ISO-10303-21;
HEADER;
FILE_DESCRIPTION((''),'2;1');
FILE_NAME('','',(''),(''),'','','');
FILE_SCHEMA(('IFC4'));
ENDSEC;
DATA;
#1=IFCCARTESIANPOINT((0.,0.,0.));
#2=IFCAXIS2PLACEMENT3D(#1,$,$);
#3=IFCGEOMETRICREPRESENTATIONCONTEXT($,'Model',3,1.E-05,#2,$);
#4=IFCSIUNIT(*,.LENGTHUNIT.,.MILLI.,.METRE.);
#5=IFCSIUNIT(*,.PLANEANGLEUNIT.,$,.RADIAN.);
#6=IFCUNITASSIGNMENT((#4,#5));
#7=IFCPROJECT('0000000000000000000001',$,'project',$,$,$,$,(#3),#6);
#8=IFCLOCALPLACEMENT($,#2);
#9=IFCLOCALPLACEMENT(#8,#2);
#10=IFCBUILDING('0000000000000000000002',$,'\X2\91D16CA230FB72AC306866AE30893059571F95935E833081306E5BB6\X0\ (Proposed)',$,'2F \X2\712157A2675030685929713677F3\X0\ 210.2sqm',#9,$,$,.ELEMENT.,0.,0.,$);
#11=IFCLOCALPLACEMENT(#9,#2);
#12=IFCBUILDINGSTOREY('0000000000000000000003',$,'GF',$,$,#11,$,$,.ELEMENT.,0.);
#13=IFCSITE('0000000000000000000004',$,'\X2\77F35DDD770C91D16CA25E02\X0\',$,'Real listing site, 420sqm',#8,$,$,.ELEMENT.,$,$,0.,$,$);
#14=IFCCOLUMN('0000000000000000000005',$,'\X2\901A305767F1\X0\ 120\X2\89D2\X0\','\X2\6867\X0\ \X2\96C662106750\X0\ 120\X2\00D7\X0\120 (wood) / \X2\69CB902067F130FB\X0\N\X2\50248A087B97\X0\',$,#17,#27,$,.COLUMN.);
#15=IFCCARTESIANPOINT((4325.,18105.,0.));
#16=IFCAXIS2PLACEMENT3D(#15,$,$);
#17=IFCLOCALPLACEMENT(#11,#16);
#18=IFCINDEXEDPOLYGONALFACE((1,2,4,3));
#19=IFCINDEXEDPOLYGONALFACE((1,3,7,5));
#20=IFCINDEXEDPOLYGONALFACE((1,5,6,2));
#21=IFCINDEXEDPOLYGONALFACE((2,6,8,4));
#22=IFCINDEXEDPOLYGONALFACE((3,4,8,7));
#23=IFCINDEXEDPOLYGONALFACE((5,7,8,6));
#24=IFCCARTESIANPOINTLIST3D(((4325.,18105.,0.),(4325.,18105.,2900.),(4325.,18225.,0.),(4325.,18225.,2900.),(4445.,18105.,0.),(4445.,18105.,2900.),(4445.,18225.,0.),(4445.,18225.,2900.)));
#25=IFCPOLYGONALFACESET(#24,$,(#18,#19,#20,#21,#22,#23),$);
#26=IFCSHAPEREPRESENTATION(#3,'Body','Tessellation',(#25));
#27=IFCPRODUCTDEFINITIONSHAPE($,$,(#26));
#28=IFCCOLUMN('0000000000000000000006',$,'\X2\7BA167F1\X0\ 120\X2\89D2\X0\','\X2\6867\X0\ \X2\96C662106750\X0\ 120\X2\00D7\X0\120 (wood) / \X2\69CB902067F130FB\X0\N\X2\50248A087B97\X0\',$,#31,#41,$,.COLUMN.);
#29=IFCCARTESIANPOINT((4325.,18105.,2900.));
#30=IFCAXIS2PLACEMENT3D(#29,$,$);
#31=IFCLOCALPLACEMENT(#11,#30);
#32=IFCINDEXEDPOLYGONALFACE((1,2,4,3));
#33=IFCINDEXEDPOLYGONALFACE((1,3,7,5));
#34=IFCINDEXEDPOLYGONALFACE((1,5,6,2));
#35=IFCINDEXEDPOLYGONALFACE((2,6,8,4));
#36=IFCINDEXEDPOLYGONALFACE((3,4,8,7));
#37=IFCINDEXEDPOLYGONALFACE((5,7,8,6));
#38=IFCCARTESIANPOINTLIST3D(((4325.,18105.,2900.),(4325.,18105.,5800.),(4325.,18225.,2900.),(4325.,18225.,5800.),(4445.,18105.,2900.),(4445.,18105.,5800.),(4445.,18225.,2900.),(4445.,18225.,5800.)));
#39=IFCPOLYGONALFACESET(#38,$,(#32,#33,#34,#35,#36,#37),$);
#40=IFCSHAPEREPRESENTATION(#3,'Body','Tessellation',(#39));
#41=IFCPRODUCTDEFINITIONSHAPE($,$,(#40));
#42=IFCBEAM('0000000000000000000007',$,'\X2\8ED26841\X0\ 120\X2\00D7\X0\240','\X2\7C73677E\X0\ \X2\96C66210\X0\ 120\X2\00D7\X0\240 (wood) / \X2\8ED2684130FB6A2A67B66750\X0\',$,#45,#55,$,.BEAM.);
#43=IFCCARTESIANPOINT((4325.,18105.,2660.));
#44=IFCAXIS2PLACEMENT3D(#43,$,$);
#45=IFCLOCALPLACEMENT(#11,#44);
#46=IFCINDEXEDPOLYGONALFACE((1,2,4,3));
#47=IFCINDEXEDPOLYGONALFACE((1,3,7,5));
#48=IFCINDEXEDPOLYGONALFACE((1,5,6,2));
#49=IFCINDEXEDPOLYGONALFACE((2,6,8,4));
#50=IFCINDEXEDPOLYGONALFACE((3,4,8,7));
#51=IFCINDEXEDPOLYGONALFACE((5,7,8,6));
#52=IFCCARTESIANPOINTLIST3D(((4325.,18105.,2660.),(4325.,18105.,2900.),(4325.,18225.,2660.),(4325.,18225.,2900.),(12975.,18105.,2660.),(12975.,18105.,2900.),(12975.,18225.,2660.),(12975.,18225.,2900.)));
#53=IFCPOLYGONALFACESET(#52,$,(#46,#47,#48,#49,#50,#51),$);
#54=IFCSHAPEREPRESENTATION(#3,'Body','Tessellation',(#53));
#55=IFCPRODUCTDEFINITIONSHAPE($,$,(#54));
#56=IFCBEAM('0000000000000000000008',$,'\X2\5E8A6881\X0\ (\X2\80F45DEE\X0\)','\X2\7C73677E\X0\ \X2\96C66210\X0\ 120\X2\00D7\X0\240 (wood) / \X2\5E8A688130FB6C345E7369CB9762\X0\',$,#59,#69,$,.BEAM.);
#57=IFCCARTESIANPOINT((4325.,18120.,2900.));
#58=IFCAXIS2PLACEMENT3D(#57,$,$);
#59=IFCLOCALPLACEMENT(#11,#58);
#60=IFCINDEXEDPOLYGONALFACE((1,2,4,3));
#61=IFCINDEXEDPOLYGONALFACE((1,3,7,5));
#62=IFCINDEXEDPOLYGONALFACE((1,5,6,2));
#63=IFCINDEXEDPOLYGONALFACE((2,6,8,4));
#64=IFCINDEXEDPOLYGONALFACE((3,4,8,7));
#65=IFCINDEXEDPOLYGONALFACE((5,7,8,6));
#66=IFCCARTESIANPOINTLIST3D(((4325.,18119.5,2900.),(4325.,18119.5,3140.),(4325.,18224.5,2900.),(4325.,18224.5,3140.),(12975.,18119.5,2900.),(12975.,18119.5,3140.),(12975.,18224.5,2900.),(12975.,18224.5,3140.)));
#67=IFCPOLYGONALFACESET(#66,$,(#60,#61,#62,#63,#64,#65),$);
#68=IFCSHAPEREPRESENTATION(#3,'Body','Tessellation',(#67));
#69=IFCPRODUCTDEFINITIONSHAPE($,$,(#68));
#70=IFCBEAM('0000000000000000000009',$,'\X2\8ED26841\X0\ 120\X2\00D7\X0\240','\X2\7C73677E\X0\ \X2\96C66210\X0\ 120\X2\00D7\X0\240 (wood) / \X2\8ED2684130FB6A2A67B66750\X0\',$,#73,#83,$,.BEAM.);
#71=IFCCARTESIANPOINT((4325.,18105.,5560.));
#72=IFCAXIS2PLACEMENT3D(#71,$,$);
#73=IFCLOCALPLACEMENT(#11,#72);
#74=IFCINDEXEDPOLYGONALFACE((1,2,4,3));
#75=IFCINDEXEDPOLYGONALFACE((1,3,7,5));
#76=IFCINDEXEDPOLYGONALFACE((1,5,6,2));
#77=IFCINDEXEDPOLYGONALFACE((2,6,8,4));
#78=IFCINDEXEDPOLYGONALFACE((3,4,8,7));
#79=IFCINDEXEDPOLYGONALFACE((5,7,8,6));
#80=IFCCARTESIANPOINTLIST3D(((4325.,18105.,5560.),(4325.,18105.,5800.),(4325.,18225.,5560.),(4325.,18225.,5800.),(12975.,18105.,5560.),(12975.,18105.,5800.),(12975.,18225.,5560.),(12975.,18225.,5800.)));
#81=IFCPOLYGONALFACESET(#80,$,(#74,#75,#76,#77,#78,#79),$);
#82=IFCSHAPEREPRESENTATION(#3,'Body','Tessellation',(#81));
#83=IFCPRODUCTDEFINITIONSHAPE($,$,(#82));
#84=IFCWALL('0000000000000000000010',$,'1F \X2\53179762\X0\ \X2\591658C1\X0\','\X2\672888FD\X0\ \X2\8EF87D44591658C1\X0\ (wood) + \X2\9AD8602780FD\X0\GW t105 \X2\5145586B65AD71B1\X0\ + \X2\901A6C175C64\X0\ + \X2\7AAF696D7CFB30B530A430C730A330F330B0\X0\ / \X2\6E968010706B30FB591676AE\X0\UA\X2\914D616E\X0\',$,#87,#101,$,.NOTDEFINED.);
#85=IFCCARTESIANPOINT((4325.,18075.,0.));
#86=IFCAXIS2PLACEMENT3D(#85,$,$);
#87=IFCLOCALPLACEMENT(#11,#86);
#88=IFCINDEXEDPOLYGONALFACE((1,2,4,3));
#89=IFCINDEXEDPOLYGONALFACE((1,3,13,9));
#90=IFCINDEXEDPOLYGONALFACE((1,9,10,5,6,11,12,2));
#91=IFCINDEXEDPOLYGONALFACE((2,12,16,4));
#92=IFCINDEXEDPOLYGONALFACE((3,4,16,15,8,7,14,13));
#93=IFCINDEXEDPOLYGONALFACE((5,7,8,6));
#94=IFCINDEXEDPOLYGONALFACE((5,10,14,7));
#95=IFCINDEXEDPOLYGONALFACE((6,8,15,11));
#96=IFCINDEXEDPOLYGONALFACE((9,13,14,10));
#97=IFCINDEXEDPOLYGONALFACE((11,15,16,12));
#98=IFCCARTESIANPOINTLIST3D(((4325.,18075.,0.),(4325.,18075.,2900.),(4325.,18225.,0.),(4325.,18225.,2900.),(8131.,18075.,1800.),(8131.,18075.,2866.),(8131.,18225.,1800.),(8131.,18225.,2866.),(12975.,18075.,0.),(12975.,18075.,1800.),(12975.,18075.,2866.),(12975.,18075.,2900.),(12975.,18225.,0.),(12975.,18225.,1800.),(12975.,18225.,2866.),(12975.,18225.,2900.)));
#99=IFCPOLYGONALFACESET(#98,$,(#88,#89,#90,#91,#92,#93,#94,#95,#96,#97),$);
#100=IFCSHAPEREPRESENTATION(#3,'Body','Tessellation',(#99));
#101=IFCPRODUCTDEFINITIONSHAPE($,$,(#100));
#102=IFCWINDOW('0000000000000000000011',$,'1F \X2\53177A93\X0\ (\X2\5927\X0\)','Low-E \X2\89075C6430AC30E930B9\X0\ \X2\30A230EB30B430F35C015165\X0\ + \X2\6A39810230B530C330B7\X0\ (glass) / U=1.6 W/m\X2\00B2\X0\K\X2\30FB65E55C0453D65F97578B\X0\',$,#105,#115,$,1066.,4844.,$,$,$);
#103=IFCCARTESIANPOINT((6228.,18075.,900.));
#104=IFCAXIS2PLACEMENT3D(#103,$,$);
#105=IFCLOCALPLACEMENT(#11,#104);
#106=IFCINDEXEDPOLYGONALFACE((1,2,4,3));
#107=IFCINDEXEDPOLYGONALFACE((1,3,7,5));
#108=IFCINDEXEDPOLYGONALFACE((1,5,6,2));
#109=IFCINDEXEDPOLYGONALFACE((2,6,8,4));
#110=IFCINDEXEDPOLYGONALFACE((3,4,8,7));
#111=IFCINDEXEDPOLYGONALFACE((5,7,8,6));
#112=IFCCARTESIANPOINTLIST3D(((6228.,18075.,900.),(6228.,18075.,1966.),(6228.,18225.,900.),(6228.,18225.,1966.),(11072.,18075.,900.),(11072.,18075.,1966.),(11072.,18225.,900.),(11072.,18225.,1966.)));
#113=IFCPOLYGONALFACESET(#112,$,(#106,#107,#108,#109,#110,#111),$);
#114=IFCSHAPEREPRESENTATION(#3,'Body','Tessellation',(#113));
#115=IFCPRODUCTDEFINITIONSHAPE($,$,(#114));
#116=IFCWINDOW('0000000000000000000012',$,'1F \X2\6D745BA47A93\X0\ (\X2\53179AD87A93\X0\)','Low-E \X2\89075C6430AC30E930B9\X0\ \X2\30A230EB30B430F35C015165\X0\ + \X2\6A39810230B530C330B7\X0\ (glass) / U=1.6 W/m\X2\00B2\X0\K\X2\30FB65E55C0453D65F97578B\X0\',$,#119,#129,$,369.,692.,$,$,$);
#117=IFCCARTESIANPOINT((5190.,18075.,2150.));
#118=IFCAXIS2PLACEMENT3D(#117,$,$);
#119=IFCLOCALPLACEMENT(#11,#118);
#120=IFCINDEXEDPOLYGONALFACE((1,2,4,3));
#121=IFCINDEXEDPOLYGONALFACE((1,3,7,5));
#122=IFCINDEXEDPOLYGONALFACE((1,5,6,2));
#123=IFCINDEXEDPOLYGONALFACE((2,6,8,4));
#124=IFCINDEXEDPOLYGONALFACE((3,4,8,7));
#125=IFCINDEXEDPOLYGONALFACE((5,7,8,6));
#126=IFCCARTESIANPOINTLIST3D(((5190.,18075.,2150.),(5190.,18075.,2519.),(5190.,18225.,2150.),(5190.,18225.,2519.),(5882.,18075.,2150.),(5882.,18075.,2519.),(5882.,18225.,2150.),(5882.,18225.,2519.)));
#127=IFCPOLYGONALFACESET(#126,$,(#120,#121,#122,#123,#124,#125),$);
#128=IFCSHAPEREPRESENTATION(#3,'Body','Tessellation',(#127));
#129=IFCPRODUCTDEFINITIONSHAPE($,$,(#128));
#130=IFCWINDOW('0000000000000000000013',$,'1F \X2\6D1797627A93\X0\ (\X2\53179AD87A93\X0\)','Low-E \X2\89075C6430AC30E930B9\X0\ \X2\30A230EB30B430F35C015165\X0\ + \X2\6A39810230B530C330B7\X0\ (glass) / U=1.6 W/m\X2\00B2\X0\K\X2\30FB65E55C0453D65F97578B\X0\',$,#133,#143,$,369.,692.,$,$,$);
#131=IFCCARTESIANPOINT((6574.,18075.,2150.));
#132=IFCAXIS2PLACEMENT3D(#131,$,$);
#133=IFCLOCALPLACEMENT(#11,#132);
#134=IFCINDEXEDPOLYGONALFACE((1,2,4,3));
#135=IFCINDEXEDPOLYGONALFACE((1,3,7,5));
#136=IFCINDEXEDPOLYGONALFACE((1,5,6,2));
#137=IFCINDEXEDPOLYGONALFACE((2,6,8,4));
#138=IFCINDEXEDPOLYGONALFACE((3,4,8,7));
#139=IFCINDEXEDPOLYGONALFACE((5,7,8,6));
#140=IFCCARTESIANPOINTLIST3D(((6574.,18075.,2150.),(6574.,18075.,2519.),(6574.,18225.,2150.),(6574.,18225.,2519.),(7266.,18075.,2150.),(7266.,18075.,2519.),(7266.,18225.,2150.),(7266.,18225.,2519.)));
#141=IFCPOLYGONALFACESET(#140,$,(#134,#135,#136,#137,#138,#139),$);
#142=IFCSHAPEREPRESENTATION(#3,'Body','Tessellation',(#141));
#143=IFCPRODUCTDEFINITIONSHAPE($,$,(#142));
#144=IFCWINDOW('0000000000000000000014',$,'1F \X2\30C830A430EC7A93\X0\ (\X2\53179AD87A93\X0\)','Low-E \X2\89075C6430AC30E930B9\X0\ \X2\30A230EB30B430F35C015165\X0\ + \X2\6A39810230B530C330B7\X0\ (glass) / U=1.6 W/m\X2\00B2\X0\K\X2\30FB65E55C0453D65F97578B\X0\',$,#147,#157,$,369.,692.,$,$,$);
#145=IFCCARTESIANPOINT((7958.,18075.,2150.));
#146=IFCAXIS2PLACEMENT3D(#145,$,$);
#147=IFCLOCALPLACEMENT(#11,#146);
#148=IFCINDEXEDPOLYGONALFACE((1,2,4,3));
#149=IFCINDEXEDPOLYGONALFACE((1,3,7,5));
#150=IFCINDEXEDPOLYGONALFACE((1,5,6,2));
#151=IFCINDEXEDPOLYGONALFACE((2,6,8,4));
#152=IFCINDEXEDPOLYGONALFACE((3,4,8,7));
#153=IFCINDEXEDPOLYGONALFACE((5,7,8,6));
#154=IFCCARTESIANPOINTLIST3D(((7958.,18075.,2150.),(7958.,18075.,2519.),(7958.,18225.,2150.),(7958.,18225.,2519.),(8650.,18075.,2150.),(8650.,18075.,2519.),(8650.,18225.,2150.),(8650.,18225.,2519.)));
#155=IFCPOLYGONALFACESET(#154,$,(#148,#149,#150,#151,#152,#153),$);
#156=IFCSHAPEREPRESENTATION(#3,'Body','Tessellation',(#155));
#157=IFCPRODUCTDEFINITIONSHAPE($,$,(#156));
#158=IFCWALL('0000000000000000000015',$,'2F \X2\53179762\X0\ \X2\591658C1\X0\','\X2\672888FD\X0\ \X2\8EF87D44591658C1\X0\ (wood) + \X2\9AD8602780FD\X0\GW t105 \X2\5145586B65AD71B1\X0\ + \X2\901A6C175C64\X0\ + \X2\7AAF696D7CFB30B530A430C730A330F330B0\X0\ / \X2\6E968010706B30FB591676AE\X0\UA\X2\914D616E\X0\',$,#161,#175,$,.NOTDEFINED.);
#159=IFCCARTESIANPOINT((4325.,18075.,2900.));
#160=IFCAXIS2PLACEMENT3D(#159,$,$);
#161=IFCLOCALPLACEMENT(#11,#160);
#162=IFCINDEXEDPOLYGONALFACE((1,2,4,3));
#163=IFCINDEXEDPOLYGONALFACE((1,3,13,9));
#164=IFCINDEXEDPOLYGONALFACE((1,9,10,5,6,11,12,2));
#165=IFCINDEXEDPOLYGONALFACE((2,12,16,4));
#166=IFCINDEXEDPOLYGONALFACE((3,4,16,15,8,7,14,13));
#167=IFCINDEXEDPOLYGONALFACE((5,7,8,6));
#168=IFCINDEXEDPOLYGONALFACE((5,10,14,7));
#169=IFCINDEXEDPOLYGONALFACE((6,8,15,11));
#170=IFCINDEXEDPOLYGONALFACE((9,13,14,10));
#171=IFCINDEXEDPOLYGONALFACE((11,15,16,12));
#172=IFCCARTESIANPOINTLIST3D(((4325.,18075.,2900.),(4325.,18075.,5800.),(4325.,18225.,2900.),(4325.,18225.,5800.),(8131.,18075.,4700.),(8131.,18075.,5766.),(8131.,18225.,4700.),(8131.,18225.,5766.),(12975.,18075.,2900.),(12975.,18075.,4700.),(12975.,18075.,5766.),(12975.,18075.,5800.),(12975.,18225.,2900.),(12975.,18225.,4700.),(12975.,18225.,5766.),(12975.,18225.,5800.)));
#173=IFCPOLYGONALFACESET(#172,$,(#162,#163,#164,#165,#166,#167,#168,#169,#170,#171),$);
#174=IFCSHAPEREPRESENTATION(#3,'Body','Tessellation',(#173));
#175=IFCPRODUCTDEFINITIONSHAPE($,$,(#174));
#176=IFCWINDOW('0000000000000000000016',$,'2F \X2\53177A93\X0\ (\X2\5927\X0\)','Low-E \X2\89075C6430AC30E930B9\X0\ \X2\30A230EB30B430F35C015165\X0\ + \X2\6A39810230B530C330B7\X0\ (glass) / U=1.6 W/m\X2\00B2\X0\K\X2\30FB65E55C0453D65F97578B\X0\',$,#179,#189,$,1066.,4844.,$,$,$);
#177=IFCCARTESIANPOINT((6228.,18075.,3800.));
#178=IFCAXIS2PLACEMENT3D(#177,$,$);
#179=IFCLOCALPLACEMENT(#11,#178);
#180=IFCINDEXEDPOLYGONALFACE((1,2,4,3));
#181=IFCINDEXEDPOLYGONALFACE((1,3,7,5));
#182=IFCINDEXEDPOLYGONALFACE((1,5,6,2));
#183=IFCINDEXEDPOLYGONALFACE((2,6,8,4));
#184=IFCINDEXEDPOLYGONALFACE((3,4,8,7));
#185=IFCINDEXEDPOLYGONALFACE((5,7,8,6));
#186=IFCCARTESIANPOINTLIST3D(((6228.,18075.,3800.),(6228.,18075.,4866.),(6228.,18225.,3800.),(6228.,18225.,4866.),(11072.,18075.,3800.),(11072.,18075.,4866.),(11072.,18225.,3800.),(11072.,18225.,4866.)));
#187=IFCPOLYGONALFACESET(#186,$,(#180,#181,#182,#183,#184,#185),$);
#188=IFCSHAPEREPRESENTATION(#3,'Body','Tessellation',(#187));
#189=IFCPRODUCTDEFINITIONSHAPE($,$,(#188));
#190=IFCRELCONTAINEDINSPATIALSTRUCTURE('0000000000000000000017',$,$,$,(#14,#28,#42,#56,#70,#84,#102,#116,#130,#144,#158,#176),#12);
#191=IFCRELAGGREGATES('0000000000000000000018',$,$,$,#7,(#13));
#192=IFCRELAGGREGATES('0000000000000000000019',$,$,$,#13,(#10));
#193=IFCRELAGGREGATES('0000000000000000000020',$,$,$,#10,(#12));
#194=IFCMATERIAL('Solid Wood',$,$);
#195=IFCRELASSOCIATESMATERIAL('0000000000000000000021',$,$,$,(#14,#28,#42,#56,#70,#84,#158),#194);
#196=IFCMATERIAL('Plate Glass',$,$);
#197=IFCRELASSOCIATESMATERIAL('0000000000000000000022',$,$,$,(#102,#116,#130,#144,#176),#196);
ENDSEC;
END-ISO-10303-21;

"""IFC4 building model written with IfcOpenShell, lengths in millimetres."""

from ifc_helpers import new_model, si_unit, frame, frame_2d, origin, place, context, project, spatial, rectangle, extrude, material, element, fill, save


model = new_model("IFC4")

# Units and contexts
model_context = context("Model", 3, precision=1e-05, world=origin())
ifc_project = project(units=[si_unit("LENGTHUNIT", "METRE", prefix="MILLI"), si_unit("PLANEANGLEUNIT", "RADIAN")], contexts=[model_context])

# Site, building, storey
site_placement = place(None, origin())
site = spatial("IfcSite", under=ifc_project, at=site_placement, Name="石川県金沢市", ObjectType="Real listing site, 420sqm", CompositionType="ELEMENT", RefElevation=0.0)
building_placement = place(site_placement, origin())
building = spatial("IfcBuilding", under=site, at=building_placement, Name="金沢・犬と暮らす土間広めの家 (Proposed)", ObjectType="2F 無垢材と天然石 210.2sqm", CompositionType="ELEMENT", ElevationOfRefHeight=0.0, ElevationOfTerrain=0.0)
storey_placement = place(building_placement, origin())
storey = spatial("IfcBuildingStorey", under=building, at=storey_placement, Name="GF", CompositionType="ELEMENT", Elevation=0.0)

# Columns
ifc_material_1 = material(Name="Solid Wood")
column_1_placement = place(storey_placement, frame((4325.0, 18105.0, 0.0)))
element("IfcColumn", 1, at=column_1_placement, inside=storey, material=ifc_material_1, Name="通し柱 120角", Description="桧 集成材 120×120 (wood) / 構造柱・N値計算", PredefinedType="COLUMN", context=model_context, shape_type="SweptSolid", body=[
    extrude(rectangle(XDim=120.0, YDim=120.0, at=frame_2d((60.0, 60.0))), frame((4325.0, 18105.0, 0.0)), (0.0, 0.0, 1.0), 2900.0),
])
column_2_placement = place(storey_placement, frame((4325.0, 18105.0, 2900.0)))
element("IfcColumn", 2, at=column_2_placement, inside=storey, material=ifc_material_1, Name="管柱 120角", Description="桧 集成材 120×120 (wood) / 構造柱・N値計算", PredefinedType="COLUMN", context=model_context, shape_type="SweptSolid", body=[
    extrude(rectangle(XDim=120.0, YDim=120.0, at=frame_2d((60.0, 60.0))), frame((4325.0, 18105.0, 2900.0)), (0.0, 0.0, 1.0), 2900.0),
])

# Beams
beam_1_placement = place(storey_placement, frame((4325.0, 18105.0, 2660.0)))
element("IfcBeam", 3, at=beam_1_placement, inside=storey, material=ifc_material_1, Name="軒桁 120×240", Description="米松 集成 120×240 (wood) / 軒桁・横架材", PredefinedType="BEAM", context=model_context, shape_type="SweptSolid", body=[
    extrude(rectangle(XDim=8650.0, YDim=120.0, at=frame_2d((4325.0, 60.0))), frame((4325.0, 18105.0, 2660.0)), (0.0, 0.0, 1.0), 240.0),
])
beam_2_placement = place(storey_placement, frame((4325.0, 18120.0, 2900.0)))
element("IfcBeam", 4, at=beam_2_placement, inside=storey, material=ifc_material_1, Name="床梁 (胴差)", Description="米松 集成 120×240 (wood) / 床梁・水平構面", PredefinedType="BEAM", context=model_context, shape_type="SweptSolid", body=[
    extrude(rectangle(XDim=8650.0, YDim=105.0, at=frame_2d((4325.0, 52.0))), frame((4325.0, 18120.0, 2900.0)), (0.0, 0.0, 1.0), 240.0),
])
beam_3_placement = place(storey_placement, frame((4325.0, 18105.0, 5560.0)))
element("IfcBeam", 5, at=beam_3_placement, inside=storey, material=ifc_material_1, Name="軒桁 120×240", Description="米松 集成 120×240 (wood) / 軒桁・横架材", PredefinedType="BEAM", context=model_context, shape_type="SweptSolid", body=[
    extrude(rectangle(XDim=8650.0, YDim=120.0, at=frame_2d((4325.0, 60.0))), frame((4325.0, 18105.0, 5560.0)), (0.0, 0.0, 1.0), 240.0),
])

# Wall, openings, windows
wall_1_placement = place(storey_placement, frame((4325.0, 18075.0, 0.0)))
wall_1 = element("IfcWall", 6, at=wall_1_placement, inside=storey, material=ifc_material_1, Name="1F 北面 外壁", Description="木製 軸組外壁 (wood) + 高性能GW t105 充填断熱 + 通気層 + 窯業系サイディング / 準耐火・外皮UA配慮", PredefinedType="NOTDEFINED", context=model_context, shape_type="SweptSolid", body=[
    extrude(rectangle(XDim=8650.0, YDim=150.0, at=frame_2d((4325.0, 75.0))), frame((4325.0, 18075.0, 0.0)), (0.0, 0.0, 1.0), 2900.0),
])
opening_1_placement = place(storey_placement, frame((6228.0, 18075.0, 900.0)))
opening_1 = element("IfcOpeningElement", 7, at=opening_1_placement, cuts=wall_1, PredefinedType="NOTDEFINED", context=model_context, shape_type="SweptSolid", body=[
    extrude(rectangle(XDim=4844.0, YDim=150.0, at=frame_2d((2422.0, 75.0))), frame((6228.0, 18075.0, 900.0)), (0.0, 0.0, 1.0), 1066.0),
])
opening_2_placement = place(storey_placement, frame((5190.0, 18075.0, 2150.0)))
opening_2 = element("IfcOpeningElement", 8, at=opening_2_placement, cuts=wall_1, PredefinedType="NOTDEFINED", context=model_context, shape_type="SweptSolid", body=[
    extrude(rectangle(XDim=692.0, YDim=150.0, at=frame_2d((346.0, 75.0))), frame((5190.0, 18075.0, 2150.0)), (0.0, 0.0, 1.0), 369.0),
])
opening_3_placement = place(storey_placement, frame((6574.0, 18075.0, 2150.0)))
opening_3 = element("IfcOpeningElement", 9, at=opening_3_placement, cuts=wall_1, PredefinedType="NOTDEFINED", context=model_context, shape_type="SweptSolid", body=[
    extrude(rectangle(XDim=692.0, YDim=150.0, at=frame_2d((346.0, 75.0))), frame((6574.0, 18075.0, 2150.0)), (0.0, 0.0, 1.0), 369.0),
])
opening_4_placement = place(storey_placement, frame((7958.0, 18075.0, 2150.0)))
opening_4 = element("IfcOpeningElement", 10, at=opening_4_placement, cuts=wall_1, PredefinedType="NOTDEFINED", context=model_context, shape_type="SweptSolid", body=[
    extrude(rectangle(XDim=692.0, YDim=150.0, at=frame_2d((346.0, 75.0))), frame((7958.0, 18075.0, 2150.0)), (0.0, 0.0, 1.0), 369.0),
])
ifc_material_2 = material(Name="Plate Glass")
window_1_placement = place(storey_placement, frame((6228.0, 18075.0, 900.0)))
window_1 = element("IfcWindow", 11, at=window_1_placement, inside=storey, material=ifc_material_2, Name="1F 北窓 (大)", Description="Low-E 複層ガラス アルゴン封入 + 樹脂サッシ (glass) / U=1.6 W/m²K・日射取得型", OverallHeight=1066.0, OverallWidth=4844.0, context=model_context, shape_type="SweptSolid", body=[
    extrude(rectangle(XDim=4844.0, YDim=150.0, at=frame_2d((2422.0, 75.0))), frame((6228.0, 18075.0, 900.0)), (0.0, 0.0, 1.0), 1066.0),
])
fill(opening_1, window_1)
window_2_placement = place(storey_placement, frame((5190.0, 18075.0, 2150.0)))
window_2 = element("IfcWindow", 12, at=window_2_placement, inside=storey, material=ifc_material_2, Name="1F 浴室窓 (北高窓)", Description="Low-E 複層ガラス アルゴン封入 + 樹脂サッシ (glass) / U=1.6 W/m²K・日射取得型", OverallHeight=369.0, OverallWidth=692.0, context=model_context, shape_type="SweptSolid", body=[
    extrude(rectangle(XDim=692.0, YDim=150.0, at=frame_2d((346.0, 75.0))), frame((5190.0, 18075.0, 2150.0)), (0.0, 0.0, 1.0), 369.0),
])
fill(opening_2, window_2)
window_3_placement = place(storey_placement, frame((6574.0, 18075.0, 2150.0)))
window_3 = element("IfcWindow", 13, at=window_3_placement, inside=storey, material=ifc_material_2, Name="1F 洗面窓 (北高窓)", Description="Low-E 複層ガラス アルゴン封入 + 樹脂サッシ (glass) / U=1.6 W/m²K・日射取得型", OverallHeight=369.0, OverallWidth=692.0, context=model_context, shape_type="SweptSolid", body=[
    extrude(rectangle(XDim=692.0, YDim=150.0, at=frame_2d((346.0, 75.0))), frame((6574.0, 18075.0, 2150.0)), (0.0, 0.0, 1.0), 369.0),
])
fill(opening_3, window_3)
window_4_placement = place(storey_placement, frame((7958.0, 18075.0, 2150.0)))
window_4 = element("IfcWindow", 14, at=window_4_placement, inside=storey, material=ifc_material_2, Name="1F トイレ窓 (北高窓)", Description="Low-E 複層ガラス アルゴン封入 + 樹脂サッシ (glass) / U=1.6 W/m²K・日射取得型", OverallHeight=369.0, OverallWidth=692.0, context=model_context, shape_type="SweptSolid", body=[
    extrude(rectangle(XDim=692.0, YDim=150.0, at=frame_2d((346.0, 75.0))), frame((7958.0, 18075.0, 2150.0)), (0.0, 0.0, 1.0), 369.0),
])
fill(opening_4, window_4)

# Wall, opening, window
wall_2_placement = place(storey_placement, frame((4325.0, 18075.0, 2900.0)))
wall_2 = element("IfcWall", 15, at=wall_2_placement, inside=storey, material=ifc_material_1, Name="2F 北面 外壁", Description="木製 軸組外壁 (wood) + 高性能GW t105 充填断熱 + 通気層 + 窯業系サイディング / 準耐火・外皮UA配慮", PredefinedType="NOTDEFINED", context=model_context, shape_type="SweptSolid", body=[
    extrude(rectangle(XDim=8650.0, YDim=150.0, at=frame_2d((4325.0, 75.0))), frame((4325.0, 18075.0, 2900.0)), (0.0, 0.0, 1.0), 2900.0),
])
opening_5_placement = place(storey_placement, frame((6228.0, 18075.0, 3800.0)))
opening_5 = element("IfcOpeningElement", 16, at=opening_5_placement, cuts=wall_2, PredefinedType="NOTDEFINED", context=model_context, shape_type="SweptSolid", body=[
    extrude(rectangle(XDim=4844.0, YDim=150.0, at=frame_2d((2422.0, 75.0))), frame((6228.0, 18075.0, 3800.0)), (0.0, 0.0, 1.0), 1066.0),
])
window_5_placement = place(storey_placement, frame((6228.0, 18075.0, 3800.0)))
window_5 = element("IfcWindow", 17, at=window_5_placement, inside=storey, material=ifc_material_2, Name="2F 北窓 (大)", Description="Low-E 複層ガラス アルゴン封入 + 樹脂サッシ (glass) / U=1.6 W/m²K・日射取得型", OverallHeight=1066.0, OverallWidth=4844.0, context=model_context, shape_type="SweptSolid", body=[
    extrude(rectangle(XDim=4844.0, YDim=150.0, at=frame_2d((2422.0, 75.0))), frame((6228.0, 18075.0, 3800.0)), (0.0, 0.0, 1.0), 1066.0),
])
fill(opening_5, window_5)

save(model, "model.ifc")
